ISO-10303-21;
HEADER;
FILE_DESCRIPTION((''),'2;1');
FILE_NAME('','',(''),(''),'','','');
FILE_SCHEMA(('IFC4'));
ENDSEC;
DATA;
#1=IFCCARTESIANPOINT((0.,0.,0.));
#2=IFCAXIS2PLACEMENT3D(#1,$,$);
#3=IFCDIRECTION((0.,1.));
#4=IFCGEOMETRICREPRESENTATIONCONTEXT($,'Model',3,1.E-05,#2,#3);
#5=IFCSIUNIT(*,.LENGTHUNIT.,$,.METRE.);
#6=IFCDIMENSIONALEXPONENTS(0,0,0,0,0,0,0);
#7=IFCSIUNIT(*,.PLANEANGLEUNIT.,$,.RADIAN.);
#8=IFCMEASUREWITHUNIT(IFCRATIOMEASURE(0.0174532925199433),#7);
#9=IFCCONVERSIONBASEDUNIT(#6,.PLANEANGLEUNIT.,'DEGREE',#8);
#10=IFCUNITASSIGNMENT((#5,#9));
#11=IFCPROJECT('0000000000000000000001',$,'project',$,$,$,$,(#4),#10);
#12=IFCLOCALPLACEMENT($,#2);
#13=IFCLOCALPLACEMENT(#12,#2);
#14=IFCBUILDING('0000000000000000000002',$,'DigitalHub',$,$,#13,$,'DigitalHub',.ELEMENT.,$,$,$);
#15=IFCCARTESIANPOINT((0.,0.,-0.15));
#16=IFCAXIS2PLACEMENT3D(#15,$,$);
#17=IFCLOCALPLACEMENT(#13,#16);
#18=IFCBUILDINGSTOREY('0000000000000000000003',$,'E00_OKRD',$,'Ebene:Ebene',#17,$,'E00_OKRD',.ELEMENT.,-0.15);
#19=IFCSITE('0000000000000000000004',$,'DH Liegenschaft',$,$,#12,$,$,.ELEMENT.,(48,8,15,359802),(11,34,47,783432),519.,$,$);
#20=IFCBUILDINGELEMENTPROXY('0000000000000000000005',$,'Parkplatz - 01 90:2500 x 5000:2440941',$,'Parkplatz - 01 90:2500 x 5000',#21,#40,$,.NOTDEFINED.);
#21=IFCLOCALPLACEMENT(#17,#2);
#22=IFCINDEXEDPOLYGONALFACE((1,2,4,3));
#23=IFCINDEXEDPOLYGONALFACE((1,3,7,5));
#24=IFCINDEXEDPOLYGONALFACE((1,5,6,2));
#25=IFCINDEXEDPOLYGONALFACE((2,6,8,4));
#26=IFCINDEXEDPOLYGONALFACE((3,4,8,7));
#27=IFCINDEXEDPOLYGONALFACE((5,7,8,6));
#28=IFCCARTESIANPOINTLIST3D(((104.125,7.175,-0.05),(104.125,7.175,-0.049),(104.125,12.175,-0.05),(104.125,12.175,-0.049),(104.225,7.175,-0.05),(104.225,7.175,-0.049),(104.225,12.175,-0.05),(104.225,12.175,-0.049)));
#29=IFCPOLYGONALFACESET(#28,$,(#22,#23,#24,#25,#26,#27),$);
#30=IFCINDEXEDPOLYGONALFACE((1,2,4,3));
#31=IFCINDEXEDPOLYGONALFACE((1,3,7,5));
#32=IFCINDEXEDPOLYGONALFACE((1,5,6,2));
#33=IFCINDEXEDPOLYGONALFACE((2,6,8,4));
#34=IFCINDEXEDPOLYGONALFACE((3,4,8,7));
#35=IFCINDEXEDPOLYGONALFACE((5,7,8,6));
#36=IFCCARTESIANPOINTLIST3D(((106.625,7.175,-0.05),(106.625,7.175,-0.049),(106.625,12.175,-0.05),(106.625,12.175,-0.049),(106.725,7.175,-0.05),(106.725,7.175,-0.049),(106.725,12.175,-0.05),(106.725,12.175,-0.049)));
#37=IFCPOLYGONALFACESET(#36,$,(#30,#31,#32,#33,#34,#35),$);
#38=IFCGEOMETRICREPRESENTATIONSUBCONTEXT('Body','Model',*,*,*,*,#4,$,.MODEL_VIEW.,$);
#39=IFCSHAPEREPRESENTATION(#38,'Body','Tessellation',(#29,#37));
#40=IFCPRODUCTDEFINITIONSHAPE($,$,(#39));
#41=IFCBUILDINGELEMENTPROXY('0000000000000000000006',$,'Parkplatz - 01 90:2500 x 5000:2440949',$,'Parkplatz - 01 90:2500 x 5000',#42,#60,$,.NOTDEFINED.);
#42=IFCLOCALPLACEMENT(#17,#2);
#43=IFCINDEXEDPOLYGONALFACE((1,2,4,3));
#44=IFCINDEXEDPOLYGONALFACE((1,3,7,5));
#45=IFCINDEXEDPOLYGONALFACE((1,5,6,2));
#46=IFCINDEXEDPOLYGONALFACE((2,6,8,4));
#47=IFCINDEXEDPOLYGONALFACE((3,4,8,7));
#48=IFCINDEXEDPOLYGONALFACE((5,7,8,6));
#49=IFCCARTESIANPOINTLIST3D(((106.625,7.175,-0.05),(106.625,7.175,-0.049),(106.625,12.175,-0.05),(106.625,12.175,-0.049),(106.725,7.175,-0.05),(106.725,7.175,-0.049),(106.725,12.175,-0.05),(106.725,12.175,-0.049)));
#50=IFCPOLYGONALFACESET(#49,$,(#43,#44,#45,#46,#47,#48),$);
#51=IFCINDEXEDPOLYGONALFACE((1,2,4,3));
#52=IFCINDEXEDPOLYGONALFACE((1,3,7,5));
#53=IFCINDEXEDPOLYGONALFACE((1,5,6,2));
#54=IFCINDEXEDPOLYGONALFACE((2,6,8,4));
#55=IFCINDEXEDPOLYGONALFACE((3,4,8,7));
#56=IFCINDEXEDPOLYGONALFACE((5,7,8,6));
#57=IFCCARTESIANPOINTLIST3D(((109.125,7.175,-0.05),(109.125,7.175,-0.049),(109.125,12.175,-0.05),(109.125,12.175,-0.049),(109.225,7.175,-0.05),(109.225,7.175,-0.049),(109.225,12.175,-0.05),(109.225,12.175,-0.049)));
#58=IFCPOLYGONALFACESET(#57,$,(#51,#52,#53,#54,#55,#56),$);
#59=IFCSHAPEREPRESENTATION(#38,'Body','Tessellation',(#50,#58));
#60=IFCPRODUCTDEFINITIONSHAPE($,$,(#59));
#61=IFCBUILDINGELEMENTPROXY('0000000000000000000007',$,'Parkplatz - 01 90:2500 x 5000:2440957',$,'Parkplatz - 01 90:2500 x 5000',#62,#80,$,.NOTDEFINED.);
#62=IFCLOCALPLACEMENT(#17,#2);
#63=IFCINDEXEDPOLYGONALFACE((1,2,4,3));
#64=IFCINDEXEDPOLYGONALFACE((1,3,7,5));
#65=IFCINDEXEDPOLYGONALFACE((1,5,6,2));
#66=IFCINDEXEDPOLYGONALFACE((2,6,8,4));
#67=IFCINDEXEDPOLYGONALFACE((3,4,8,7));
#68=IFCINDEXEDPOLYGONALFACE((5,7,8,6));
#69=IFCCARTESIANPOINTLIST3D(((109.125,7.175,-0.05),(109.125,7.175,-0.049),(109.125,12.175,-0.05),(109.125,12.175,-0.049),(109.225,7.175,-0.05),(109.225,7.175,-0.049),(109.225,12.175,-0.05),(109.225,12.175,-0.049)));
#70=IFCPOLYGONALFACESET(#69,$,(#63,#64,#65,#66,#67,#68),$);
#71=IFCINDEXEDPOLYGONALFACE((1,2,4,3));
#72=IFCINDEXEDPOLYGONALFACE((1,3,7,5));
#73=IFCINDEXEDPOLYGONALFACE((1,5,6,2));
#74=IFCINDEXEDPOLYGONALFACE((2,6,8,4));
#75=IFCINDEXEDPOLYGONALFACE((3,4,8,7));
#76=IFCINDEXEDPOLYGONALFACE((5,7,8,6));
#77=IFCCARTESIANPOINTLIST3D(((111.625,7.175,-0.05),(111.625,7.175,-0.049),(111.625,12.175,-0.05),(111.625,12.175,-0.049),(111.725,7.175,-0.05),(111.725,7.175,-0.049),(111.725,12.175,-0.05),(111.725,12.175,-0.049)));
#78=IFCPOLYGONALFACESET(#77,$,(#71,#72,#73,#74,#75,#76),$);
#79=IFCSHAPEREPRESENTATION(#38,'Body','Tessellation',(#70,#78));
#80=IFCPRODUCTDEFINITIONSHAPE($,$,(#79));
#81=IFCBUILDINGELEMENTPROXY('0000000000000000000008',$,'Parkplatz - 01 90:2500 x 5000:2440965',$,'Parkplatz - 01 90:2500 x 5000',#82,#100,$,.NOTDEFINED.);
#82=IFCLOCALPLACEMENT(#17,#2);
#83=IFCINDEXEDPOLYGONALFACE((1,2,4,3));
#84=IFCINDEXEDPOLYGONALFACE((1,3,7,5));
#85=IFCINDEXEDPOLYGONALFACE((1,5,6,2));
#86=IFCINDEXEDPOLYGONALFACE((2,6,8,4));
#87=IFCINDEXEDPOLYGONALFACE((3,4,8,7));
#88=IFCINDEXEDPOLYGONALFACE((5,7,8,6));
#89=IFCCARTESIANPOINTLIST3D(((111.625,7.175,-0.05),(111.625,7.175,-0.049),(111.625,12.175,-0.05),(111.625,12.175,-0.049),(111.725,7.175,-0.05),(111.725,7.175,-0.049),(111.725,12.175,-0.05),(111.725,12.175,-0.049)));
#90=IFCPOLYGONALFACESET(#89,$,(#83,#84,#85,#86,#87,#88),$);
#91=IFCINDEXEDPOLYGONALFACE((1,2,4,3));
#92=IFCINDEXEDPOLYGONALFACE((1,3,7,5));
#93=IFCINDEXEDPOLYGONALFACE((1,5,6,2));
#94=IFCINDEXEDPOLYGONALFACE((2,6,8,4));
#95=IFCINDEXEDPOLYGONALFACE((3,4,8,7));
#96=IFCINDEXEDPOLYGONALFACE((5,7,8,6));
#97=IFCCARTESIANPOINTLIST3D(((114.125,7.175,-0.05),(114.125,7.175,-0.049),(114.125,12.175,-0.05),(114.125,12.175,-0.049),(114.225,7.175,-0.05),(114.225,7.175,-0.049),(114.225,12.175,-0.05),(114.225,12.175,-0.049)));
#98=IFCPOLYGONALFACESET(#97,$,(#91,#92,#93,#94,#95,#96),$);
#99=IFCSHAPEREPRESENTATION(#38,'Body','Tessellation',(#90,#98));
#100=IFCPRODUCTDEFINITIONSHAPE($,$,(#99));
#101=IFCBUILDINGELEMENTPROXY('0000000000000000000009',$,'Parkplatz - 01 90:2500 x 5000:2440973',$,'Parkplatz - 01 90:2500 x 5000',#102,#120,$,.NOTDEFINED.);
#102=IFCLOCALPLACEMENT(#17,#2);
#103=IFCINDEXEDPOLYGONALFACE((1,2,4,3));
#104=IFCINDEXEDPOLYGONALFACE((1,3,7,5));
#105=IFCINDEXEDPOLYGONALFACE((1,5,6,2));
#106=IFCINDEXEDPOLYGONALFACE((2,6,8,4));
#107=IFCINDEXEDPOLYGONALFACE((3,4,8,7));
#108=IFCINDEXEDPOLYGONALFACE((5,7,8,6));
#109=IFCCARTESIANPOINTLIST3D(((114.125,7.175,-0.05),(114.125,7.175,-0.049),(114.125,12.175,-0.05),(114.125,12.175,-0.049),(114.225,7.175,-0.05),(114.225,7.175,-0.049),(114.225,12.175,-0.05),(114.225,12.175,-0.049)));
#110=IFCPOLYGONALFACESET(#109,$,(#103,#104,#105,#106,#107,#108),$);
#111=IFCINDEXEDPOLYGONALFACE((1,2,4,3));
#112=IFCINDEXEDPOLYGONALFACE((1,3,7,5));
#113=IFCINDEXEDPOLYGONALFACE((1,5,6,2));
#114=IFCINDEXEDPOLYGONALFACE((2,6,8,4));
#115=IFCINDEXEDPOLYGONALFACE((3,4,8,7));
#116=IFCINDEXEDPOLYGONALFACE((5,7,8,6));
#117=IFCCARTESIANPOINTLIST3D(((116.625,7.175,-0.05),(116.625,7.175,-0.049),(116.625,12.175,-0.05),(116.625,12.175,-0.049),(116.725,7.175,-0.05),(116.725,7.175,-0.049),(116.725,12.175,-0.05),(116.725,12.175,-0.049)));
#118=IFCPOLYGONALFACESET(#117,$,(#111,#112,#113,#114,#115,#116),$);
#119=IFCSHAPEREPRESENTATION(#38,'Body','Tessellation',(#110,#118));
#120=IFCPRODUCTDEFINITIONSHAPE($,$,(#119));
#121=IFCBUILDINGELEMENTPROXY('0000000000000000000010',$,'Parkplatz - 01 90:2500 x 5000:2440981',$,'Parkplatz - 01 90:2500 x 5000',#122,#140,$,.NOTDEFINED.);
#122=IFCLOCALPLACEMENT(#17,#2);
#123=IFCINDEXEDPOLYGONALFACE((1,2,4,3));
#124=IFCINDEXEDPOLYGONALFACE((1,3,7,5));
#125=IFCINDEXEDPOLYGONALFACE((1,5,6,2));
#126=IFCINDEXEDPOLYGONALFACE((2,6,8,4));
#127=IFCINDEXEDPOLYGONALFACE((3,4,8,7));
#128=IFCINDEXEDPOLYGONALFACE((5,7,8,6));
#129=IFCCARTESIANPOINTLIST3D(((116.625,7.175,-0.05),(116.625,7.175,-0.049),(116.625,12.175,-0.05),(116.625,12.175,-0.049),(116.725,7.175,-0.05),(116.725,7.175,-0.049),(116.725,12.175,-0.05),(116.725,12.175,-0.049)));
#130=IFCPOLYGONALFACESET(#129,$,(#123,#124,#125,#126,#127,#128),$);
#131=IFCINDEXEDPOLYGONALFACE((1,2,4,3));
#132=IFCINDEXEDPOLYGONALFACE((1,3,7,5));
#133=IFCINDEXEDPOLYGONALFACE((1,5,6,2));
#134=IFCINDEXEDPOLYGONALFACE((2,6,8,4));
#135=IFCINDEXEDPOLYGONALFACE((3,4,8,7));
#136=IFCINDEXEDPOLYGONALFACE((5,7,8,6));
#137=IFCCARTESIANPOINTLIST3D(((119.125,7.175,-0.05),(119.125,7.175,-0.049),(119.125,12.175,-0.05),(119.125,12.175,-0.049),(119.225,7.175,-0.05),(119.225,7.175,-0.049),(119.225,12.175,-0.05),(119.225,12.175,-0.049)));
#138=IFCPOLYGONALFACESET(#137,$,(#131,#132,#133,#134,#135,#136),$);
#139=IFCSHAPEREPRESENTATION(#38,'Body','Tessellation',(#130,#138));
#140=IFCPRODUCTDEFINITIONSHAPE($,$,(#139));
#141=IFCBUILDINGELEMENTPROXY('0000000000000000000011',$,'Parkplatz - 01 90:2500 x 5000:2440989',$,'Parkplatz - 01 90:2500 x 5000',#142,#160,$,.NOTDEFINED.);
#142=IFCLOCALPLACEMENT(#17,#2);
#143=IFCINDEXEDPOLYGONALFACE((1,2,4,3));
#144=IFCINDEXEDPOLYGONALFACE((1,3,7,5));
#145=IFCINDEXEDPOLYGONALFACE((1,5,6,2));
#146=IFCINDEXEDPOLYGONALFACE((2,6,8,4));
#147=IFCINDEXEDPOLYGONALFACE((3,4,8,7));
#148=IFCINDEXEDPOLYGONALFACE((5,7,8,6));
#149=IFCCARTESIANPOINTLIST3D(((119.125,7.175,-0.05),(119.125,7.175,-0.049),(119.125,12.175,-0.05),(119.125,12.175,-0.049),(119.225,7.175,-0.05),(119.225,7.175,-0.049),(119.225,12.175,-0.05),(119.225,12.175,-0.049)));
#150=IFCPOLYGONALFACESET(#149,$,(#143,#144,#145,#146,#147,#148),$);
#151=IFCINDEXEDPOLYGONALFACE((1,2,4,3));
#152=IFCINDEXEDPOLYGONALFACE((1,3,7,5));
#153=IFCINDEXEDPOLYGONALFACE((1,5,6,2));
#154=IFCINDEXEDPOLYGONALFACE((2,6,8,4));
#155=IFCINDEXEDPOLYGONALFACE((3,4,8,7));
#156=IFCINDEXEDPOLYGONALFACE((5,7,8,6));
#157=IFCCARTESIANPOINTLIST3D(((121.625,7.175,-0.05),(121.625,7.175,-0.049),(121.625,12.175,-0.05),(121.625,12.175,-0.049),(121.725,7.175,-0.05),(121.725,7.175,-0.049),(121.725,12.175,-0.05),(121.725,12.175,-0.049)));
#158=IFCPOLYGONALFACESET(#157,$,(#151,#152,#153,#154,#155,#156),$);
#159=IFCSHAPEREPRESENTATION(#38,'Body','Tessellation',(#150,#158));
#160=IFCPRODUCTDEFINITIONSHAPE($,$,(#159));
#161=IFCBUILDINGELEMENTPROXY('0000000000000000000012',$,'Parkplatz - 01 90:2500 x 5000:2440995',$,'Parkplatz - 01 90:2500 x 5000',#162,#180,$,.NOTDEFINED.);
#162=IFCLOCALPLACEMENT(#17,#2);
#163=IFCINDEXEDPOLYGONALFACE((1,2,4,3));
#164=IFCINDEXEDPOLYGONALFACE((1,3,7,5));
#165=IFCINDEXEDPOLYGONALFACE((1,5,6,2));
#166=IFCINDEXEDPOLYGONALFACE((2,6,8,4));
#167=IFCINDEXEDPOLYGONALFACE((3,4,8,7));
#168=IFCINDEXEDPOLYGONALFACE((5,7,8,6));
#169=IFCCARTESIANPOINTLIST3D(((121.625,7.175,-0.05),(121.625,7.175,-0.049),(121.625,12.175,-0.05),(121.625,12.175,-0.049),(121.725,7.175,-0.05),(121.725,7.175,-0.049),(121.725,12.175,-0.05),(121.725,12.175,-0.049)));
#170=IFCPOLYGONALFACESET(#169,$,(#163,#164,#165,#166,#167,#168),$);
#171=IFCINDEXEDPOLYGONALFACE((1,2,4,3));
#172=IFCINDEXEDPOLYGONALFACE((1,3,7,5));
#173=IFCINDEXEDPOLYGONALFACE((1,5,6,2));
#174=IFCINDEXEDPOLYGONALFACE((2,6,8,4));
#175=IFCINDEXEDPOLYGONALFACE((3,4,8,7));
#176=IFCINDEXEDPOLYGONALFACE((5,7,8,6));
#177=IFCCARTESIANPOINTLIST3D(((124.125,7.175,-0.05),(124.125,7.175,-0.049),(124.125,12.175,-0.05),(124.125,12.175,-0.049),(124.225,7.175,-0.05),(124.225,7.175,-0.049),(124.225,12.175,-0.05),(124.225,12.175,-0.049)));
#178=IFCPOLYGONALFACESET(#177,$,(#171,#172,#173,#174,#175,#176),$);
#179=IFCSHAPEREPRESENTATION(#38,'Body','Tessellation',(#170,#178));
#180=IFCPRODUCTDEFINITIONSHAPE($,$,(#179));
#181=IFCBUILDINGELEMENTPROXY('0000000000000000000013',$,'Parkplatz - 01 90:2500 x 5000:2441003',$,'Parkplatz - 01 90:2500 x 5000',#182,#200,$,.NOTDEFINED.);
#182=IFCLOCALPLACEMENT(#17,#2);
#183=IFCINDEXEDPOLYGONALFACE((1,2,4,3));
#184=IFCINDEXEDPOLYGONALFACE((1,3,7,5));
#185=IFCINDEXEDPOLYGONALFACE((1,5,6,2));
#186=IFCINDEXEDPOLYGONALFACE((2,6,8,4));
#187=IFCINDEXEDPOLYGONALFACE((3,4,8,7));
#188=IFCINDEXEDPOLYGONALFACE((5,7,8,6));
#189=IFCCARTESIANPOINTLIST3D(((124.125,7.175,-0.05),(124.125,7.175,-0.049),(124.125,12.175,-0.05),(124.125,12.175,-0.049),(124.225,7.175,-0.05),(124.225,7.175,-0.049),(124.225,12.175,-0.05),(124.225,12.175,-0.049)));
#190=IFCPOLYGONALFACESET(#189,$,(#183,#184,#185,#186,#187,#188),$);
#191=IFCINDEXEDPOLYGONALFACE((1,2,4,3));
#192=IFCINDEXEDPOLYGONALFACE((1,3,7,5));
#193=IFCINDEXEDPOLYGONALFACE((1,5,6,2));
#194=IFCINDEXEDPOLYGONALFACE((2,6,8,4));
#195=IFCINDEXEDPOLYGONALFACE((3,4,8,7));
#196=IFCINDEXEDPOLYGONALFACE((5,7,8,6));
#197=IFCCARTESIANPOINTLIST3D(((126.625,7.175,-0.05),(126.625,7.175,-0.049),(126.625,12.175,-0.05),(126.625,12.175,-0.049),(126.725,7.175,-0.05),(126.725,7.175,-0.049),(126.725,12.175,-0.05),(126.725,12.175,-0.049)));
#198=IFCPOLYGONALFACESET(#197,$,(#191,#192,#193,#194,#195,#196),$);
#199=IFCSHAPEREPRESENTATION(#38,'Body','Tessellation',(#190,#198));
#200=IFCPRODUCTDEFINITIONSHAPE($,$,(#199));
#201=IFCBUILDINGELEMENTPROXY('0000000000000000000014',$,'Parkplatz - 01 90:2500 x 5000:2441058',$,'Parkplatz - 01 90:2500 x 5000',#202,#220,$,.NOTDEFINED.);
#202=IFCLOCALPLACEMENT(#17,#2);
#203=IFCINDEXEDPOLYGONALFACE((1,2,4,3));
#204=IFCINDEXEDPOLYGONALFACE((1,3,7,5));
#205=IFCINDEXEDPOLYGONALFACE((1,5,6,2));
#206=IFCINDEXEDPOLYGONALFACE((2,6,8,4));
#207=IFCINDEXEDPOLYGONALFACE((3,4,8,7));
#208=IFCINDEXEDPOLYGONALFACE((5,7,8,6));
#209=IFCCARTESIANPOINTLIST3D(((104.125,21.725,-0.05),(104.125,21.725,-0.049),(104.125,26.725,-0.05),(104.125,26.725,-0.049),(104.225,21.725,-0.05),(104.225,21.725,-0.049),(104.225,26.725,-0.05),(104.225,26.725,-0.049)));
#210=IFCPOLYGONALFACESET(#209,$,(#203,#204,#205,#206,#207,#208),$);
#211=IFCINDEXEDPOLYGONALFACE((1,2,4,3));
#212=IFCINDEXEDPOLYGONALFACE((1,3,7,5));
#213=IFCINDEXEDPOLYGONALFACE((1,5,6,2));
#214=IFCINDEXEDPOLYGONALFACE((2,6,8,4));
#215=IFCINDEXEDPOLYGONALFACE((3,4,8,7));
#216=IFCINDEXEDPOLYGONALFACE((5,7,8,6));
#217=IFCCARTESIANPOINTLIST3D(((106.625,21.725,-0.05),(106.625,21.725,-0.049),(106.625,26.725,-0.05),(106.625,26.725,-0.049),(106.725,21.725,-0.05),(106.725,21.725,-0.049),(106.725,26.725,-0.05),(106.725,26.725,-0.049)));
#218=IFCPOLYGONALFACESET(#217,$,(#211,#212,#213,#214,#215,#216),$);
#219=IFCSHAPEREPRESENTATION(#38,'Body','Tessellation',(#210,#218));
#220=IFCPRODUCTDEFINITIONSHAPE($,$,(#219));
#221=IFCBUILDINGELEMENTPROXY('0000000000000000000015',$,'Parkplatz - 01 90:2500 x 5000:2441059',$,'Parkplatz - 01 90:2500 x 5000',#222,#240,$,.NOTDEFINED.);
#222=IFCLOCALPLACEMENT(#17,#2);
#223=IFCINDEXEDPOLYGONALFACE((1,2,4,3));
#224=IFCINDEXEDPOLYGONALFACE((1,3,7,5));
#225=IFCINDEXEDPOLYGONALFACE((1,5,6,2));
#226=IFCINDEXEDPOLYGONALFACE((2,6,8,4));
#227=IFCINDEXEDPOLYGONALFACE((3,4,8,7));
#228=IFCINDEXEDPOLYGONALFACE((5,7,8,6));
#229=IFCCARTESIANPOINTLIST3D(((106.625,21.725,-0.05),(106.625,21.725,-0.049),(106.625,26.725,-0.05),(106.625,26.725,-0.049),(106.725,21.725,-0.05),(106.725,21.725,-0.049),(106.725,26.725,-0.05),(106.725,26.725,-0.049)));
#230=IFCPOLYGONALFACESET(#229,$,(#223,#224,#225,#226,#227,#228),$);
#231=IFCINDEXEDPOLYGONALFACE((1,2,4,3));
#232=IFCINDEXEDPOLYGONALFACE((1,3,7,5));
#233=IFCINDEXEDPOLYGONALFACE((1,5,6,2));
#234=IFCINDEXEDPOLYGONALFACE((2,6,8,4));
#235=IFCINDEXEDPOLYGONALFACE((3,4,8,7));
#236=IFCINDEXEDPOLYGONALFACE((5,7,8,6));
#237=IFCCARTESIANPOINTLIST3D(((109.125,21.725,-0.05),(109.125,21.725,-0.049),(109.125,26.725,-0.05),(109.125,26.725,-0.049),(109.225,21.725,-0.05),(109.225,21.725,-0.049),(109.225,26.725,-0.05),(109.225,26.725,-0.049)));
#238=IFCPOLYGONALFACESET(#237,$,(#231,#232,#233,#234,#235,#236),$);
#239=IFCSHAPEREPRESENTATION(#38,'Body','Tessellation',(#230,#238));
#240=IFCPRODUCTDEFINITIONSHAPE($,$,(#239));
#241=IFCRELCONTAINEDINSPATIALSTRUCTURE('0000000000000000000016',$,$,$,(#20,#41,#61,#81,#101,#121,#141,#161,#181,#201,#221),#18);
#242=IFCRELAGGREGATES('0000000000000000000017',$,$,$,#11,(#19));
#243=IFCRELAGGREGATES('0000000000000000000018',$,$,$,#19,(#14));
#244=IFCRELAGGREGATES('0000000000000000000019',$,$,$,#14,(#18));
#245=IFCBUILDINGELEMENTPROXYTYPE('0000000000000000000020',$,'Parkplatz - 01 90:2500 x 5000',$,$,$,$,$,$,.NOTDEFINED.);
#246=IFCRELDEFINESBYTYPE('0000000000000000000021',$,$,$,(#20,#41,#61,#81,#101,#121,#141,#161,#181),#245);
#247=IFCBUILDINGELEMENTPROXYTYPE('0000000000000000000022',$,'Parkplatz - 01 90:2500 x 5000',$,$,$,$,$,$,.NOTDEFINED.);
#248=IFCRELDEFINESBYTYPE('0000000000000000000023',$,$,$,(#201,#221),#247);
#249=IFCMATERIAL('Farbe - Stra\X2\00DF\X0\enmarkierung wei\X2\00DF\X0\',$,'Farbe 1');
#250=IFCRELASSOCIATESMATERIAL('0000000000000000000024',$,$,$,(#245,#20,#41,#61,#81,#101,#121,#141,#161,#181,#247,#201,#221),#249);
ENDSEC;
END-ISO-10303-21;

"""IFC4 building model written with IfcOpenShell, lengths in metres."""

from ifc_helpers import new_model, entity, si_unit, converted_unit, direction, frame, origin, place, context, subcontext, project, spatial, indexed_curve, outline, extrude, source, transform, mapped, material, type_object, type_shapes, element, save


model = new_model("IFC4")

# Units and contexts
model_context = context("Model", 3, precision=1e-05, world=origin(), true_north=direction((0.0, 1.0)))
body_context = subcontext(model_context, "Body", "Model", "MODEL_VIEW")
ifc_project = project(units=[si_unit("LENGTHUNIT", "METRE"), converted_unit("PLANEANGLEUNIT", "DEGREE", entity("IfcRatioMeasure", 0.0174532925199433), si_unit("PLANEANGLEUNIT", "RADIAN"), dimensions=[0, 0, 0, 0, 0, 0, 0])], contexts=[model_context])

# Site, building, storey
site_placement = place(None, frame((0.0, 0.0, 0.0)))
site = spatial("IfcSite", under=ifc_project, at=site_placement, Name="DH Liegenschaft", CompositionType="ELEMENT", RefLatitude=(48, 8, 15, 359802), RefLongitude=(11, 34, 47, 783432), RefElevation=519.0)
building_placement = place(site_placement, origin())
building = spatial("IfcBuilding", under=site, at=building_placement, Name="DigitalHub", LongName="DigitalHub", CompositionType="ELEMENT")
storey_placement = place(building_placement, frame((0.0, 0.0, -0.15)))
storey = spatial("IfcBuildingStorey", under=building, at=storey_placement, Name="E00_OKRD", ObjectType="Ebene:Ebene", LongName="E00_OKRD", CompositionType="ELEMENT", Elevation=-0.15)

# Building element proxies
ifc_material_1 = material(Name="Farbe - Straßenmarkierung weiß", Category="Farbe 1")
building_element_proxy_type_1 = type_object("IfcBuildingElementProxyType", Name="Parkplatz - 01 90:2500 x 5000", PredefinedType="NOTDEFINED", material=ifc_material_1)
shared_shape_1 = source(origin(), body_context, "Body", "SweptSolid", [
    extrude(outline(indexed_curve([(-2.5, -0.05), (2.5, -0.05), (2.5, 0.05), (-2.5, 0.05), (-2.5, -0.05)], self_intersect=False)), frame((2.5456, -2.5, 0.0), z_axis=(0.0, 0.0, 1.0), x_axis=(0.0, -1.0, 0.0)), (0.0, 0.0, 1.0), 0.001),
    extrude(outline(indexed_curve([(-0.05, -2.5), (0.05, -2.5), (0.05, 2.5), (-0.05, 2.5), (-0.05, -2.5)], self_intersect=False)), frame((0.0456, -2.5, 0.0), z_axis=(0.0, 0.0, 1.0), x_axis=(-1.0, 0.0, 0.0)), (0.0, 0.0, 1.0), 0.001),
])
type_shapes(building_element_proxy_type_1, [shared_shape_1])
for number, where, z_axis, x_axis, name in (
    (1, (106.7206, 7.175, -0.05), (0.0, 0.0, 1.0), (-1.0, 0.0, 0.0), "Parkplatz - 01 90:2500 x 5000:2440941"),
    (2, (109.2206, 7.175, -0.05), (0.0, 0.0, 1.0), (-1.0, 0.0, 0.0), "Parkplatz - 01 90:2500 x 5000:2440949"),
    (3, (111.7206, 7.175, -0.05), (0.0, 0.0, 1.0), (-1.0, 0.0, 0.0), "Parkplatz - 01 90:2500 x 5000:2440957"),
    (4, (114.2206, 7.175, -0.05), (0.0, 0.0, 1.0), (-1.0, 0.0, 0.0), "Parkplatz - 01 90:2500 x 5000:2440965"),
    (5, (116.7206, 7.175, -0.05), (0.0, 0.0, 1.0), (-1.0, 0.0, 0.0), "Parkplatz - 01 90:2500 x 5000:2440973"),
    (6, (119.2206, 7.175, -0.05), (0.0, 0.0, 1.0), (-1.0, 0.0, 0.0), "Parkplatz - 01 90:2500 x 5000:2440981"),
    (7, (121.7206, 7.175, -0.05), (0.0, 0.0, 1.0), (-1.0, 0.0, 0.0), "Parkplatz - 01 90:2500 x 5000:2440989"),
    (8, (124.2206, 7.175, -0.05), (0.0, 0.0, 1.0), (-1.0, 0.0, 0.0), "Parkplatz - 01 90:2500 x 5000:2440995"),
    (9, (126.7206, 7.175, -0.05), (0.0, 0.0, 1.0), (-1.0, 0.0, 0.0), "Parkplatz - 01 90:2500 x 5000:2441003"),
):
    element("IfcBuildingElementProxy", number, at=place(storey_placement, frame(where, z_axis=z_axis, x_axis=x_axis)), inside=storey, type_object=building_element_proxy_type_1, material=ifc_material_1, Name=name, ObjectType="Parkplatz - 01 90:2500 x 5000", PredefinedType="NOTDEFINED", context=body_context, shape_type="MappedRepresentation", body=[
        mapped(shared_shape_1, transform((0.0, 0.0, 0.0), scale=1.0)),
    ])
building_element_proxy_type_2 = type_object("IfcBuildingElementProxyType", Name="Parkplatz - 01 90:2500 x 5000", PredefinedType="NOTDEFINED", material=ifc_material_1)
shared_shape_2 = source(origin(), body_context, "Body", "SweptSolid", [
    extrude(outline(indexed_curve([(-0.05, -2.5), (0.05, -2.5), (0.05, 2.5), (-0.05, 2.5), (-0.05, -2.5)], self_intersect=False)), frame((2.5456, 2.5, 0.0)), (0.0, 0.0, 1.0), 0.001),
    extrude(outline(indexed_curve([(-2.5, -0.05), (2.5, -0.05), (2.5, 0.05), (-2.5, 0.05), (-2.5, -0.05)], self_intersect=False)), frame((0.0456, 2.5, 0.0), z_axis=(0.0, 0.0, 1.0), x_axis=(0.0, 1.0, 0.0)), (0.0, 0.0, 1.0), 0.001),
])
type_shapes(building_element_proxy_type_2, [shared_shape_2])
for number, where, z_axis, x_axis, name in (
    (10, (106.7206, 26.725, -0.05), (0.0, 0.0, 1.0), (-1.0, 0.0, 0.0), "Parkplatz - 01 90:2500 x 5000:2441058"),
    (11, (109.2206, 26.725, -0.05), (0.0, 0.0, 1.0), (-1.0, 0.0, 0.0), "Parkplatz - 01 90:2500 x 5000:2441059"),
):
    element("IfcBuildingElementProxy", number, at=place(storey_placement, frame(where, z_axis=z_axis, x_axis=x_axis)), inside=storey, type_object=building_element_proxy_type_2, material=ifc_material_1, Name=name, ObjectType="Parkplatz - 01 90:2500 x 5000", PredefinedType="NOTDEFINED", context=body_context, shape_type="MappedRepresentation", body=[
        mapped(shared_shape_2, transform((0.0, 0.0, 0.0), scale=1.0)),
    ])

save(model, "model.ifc")
